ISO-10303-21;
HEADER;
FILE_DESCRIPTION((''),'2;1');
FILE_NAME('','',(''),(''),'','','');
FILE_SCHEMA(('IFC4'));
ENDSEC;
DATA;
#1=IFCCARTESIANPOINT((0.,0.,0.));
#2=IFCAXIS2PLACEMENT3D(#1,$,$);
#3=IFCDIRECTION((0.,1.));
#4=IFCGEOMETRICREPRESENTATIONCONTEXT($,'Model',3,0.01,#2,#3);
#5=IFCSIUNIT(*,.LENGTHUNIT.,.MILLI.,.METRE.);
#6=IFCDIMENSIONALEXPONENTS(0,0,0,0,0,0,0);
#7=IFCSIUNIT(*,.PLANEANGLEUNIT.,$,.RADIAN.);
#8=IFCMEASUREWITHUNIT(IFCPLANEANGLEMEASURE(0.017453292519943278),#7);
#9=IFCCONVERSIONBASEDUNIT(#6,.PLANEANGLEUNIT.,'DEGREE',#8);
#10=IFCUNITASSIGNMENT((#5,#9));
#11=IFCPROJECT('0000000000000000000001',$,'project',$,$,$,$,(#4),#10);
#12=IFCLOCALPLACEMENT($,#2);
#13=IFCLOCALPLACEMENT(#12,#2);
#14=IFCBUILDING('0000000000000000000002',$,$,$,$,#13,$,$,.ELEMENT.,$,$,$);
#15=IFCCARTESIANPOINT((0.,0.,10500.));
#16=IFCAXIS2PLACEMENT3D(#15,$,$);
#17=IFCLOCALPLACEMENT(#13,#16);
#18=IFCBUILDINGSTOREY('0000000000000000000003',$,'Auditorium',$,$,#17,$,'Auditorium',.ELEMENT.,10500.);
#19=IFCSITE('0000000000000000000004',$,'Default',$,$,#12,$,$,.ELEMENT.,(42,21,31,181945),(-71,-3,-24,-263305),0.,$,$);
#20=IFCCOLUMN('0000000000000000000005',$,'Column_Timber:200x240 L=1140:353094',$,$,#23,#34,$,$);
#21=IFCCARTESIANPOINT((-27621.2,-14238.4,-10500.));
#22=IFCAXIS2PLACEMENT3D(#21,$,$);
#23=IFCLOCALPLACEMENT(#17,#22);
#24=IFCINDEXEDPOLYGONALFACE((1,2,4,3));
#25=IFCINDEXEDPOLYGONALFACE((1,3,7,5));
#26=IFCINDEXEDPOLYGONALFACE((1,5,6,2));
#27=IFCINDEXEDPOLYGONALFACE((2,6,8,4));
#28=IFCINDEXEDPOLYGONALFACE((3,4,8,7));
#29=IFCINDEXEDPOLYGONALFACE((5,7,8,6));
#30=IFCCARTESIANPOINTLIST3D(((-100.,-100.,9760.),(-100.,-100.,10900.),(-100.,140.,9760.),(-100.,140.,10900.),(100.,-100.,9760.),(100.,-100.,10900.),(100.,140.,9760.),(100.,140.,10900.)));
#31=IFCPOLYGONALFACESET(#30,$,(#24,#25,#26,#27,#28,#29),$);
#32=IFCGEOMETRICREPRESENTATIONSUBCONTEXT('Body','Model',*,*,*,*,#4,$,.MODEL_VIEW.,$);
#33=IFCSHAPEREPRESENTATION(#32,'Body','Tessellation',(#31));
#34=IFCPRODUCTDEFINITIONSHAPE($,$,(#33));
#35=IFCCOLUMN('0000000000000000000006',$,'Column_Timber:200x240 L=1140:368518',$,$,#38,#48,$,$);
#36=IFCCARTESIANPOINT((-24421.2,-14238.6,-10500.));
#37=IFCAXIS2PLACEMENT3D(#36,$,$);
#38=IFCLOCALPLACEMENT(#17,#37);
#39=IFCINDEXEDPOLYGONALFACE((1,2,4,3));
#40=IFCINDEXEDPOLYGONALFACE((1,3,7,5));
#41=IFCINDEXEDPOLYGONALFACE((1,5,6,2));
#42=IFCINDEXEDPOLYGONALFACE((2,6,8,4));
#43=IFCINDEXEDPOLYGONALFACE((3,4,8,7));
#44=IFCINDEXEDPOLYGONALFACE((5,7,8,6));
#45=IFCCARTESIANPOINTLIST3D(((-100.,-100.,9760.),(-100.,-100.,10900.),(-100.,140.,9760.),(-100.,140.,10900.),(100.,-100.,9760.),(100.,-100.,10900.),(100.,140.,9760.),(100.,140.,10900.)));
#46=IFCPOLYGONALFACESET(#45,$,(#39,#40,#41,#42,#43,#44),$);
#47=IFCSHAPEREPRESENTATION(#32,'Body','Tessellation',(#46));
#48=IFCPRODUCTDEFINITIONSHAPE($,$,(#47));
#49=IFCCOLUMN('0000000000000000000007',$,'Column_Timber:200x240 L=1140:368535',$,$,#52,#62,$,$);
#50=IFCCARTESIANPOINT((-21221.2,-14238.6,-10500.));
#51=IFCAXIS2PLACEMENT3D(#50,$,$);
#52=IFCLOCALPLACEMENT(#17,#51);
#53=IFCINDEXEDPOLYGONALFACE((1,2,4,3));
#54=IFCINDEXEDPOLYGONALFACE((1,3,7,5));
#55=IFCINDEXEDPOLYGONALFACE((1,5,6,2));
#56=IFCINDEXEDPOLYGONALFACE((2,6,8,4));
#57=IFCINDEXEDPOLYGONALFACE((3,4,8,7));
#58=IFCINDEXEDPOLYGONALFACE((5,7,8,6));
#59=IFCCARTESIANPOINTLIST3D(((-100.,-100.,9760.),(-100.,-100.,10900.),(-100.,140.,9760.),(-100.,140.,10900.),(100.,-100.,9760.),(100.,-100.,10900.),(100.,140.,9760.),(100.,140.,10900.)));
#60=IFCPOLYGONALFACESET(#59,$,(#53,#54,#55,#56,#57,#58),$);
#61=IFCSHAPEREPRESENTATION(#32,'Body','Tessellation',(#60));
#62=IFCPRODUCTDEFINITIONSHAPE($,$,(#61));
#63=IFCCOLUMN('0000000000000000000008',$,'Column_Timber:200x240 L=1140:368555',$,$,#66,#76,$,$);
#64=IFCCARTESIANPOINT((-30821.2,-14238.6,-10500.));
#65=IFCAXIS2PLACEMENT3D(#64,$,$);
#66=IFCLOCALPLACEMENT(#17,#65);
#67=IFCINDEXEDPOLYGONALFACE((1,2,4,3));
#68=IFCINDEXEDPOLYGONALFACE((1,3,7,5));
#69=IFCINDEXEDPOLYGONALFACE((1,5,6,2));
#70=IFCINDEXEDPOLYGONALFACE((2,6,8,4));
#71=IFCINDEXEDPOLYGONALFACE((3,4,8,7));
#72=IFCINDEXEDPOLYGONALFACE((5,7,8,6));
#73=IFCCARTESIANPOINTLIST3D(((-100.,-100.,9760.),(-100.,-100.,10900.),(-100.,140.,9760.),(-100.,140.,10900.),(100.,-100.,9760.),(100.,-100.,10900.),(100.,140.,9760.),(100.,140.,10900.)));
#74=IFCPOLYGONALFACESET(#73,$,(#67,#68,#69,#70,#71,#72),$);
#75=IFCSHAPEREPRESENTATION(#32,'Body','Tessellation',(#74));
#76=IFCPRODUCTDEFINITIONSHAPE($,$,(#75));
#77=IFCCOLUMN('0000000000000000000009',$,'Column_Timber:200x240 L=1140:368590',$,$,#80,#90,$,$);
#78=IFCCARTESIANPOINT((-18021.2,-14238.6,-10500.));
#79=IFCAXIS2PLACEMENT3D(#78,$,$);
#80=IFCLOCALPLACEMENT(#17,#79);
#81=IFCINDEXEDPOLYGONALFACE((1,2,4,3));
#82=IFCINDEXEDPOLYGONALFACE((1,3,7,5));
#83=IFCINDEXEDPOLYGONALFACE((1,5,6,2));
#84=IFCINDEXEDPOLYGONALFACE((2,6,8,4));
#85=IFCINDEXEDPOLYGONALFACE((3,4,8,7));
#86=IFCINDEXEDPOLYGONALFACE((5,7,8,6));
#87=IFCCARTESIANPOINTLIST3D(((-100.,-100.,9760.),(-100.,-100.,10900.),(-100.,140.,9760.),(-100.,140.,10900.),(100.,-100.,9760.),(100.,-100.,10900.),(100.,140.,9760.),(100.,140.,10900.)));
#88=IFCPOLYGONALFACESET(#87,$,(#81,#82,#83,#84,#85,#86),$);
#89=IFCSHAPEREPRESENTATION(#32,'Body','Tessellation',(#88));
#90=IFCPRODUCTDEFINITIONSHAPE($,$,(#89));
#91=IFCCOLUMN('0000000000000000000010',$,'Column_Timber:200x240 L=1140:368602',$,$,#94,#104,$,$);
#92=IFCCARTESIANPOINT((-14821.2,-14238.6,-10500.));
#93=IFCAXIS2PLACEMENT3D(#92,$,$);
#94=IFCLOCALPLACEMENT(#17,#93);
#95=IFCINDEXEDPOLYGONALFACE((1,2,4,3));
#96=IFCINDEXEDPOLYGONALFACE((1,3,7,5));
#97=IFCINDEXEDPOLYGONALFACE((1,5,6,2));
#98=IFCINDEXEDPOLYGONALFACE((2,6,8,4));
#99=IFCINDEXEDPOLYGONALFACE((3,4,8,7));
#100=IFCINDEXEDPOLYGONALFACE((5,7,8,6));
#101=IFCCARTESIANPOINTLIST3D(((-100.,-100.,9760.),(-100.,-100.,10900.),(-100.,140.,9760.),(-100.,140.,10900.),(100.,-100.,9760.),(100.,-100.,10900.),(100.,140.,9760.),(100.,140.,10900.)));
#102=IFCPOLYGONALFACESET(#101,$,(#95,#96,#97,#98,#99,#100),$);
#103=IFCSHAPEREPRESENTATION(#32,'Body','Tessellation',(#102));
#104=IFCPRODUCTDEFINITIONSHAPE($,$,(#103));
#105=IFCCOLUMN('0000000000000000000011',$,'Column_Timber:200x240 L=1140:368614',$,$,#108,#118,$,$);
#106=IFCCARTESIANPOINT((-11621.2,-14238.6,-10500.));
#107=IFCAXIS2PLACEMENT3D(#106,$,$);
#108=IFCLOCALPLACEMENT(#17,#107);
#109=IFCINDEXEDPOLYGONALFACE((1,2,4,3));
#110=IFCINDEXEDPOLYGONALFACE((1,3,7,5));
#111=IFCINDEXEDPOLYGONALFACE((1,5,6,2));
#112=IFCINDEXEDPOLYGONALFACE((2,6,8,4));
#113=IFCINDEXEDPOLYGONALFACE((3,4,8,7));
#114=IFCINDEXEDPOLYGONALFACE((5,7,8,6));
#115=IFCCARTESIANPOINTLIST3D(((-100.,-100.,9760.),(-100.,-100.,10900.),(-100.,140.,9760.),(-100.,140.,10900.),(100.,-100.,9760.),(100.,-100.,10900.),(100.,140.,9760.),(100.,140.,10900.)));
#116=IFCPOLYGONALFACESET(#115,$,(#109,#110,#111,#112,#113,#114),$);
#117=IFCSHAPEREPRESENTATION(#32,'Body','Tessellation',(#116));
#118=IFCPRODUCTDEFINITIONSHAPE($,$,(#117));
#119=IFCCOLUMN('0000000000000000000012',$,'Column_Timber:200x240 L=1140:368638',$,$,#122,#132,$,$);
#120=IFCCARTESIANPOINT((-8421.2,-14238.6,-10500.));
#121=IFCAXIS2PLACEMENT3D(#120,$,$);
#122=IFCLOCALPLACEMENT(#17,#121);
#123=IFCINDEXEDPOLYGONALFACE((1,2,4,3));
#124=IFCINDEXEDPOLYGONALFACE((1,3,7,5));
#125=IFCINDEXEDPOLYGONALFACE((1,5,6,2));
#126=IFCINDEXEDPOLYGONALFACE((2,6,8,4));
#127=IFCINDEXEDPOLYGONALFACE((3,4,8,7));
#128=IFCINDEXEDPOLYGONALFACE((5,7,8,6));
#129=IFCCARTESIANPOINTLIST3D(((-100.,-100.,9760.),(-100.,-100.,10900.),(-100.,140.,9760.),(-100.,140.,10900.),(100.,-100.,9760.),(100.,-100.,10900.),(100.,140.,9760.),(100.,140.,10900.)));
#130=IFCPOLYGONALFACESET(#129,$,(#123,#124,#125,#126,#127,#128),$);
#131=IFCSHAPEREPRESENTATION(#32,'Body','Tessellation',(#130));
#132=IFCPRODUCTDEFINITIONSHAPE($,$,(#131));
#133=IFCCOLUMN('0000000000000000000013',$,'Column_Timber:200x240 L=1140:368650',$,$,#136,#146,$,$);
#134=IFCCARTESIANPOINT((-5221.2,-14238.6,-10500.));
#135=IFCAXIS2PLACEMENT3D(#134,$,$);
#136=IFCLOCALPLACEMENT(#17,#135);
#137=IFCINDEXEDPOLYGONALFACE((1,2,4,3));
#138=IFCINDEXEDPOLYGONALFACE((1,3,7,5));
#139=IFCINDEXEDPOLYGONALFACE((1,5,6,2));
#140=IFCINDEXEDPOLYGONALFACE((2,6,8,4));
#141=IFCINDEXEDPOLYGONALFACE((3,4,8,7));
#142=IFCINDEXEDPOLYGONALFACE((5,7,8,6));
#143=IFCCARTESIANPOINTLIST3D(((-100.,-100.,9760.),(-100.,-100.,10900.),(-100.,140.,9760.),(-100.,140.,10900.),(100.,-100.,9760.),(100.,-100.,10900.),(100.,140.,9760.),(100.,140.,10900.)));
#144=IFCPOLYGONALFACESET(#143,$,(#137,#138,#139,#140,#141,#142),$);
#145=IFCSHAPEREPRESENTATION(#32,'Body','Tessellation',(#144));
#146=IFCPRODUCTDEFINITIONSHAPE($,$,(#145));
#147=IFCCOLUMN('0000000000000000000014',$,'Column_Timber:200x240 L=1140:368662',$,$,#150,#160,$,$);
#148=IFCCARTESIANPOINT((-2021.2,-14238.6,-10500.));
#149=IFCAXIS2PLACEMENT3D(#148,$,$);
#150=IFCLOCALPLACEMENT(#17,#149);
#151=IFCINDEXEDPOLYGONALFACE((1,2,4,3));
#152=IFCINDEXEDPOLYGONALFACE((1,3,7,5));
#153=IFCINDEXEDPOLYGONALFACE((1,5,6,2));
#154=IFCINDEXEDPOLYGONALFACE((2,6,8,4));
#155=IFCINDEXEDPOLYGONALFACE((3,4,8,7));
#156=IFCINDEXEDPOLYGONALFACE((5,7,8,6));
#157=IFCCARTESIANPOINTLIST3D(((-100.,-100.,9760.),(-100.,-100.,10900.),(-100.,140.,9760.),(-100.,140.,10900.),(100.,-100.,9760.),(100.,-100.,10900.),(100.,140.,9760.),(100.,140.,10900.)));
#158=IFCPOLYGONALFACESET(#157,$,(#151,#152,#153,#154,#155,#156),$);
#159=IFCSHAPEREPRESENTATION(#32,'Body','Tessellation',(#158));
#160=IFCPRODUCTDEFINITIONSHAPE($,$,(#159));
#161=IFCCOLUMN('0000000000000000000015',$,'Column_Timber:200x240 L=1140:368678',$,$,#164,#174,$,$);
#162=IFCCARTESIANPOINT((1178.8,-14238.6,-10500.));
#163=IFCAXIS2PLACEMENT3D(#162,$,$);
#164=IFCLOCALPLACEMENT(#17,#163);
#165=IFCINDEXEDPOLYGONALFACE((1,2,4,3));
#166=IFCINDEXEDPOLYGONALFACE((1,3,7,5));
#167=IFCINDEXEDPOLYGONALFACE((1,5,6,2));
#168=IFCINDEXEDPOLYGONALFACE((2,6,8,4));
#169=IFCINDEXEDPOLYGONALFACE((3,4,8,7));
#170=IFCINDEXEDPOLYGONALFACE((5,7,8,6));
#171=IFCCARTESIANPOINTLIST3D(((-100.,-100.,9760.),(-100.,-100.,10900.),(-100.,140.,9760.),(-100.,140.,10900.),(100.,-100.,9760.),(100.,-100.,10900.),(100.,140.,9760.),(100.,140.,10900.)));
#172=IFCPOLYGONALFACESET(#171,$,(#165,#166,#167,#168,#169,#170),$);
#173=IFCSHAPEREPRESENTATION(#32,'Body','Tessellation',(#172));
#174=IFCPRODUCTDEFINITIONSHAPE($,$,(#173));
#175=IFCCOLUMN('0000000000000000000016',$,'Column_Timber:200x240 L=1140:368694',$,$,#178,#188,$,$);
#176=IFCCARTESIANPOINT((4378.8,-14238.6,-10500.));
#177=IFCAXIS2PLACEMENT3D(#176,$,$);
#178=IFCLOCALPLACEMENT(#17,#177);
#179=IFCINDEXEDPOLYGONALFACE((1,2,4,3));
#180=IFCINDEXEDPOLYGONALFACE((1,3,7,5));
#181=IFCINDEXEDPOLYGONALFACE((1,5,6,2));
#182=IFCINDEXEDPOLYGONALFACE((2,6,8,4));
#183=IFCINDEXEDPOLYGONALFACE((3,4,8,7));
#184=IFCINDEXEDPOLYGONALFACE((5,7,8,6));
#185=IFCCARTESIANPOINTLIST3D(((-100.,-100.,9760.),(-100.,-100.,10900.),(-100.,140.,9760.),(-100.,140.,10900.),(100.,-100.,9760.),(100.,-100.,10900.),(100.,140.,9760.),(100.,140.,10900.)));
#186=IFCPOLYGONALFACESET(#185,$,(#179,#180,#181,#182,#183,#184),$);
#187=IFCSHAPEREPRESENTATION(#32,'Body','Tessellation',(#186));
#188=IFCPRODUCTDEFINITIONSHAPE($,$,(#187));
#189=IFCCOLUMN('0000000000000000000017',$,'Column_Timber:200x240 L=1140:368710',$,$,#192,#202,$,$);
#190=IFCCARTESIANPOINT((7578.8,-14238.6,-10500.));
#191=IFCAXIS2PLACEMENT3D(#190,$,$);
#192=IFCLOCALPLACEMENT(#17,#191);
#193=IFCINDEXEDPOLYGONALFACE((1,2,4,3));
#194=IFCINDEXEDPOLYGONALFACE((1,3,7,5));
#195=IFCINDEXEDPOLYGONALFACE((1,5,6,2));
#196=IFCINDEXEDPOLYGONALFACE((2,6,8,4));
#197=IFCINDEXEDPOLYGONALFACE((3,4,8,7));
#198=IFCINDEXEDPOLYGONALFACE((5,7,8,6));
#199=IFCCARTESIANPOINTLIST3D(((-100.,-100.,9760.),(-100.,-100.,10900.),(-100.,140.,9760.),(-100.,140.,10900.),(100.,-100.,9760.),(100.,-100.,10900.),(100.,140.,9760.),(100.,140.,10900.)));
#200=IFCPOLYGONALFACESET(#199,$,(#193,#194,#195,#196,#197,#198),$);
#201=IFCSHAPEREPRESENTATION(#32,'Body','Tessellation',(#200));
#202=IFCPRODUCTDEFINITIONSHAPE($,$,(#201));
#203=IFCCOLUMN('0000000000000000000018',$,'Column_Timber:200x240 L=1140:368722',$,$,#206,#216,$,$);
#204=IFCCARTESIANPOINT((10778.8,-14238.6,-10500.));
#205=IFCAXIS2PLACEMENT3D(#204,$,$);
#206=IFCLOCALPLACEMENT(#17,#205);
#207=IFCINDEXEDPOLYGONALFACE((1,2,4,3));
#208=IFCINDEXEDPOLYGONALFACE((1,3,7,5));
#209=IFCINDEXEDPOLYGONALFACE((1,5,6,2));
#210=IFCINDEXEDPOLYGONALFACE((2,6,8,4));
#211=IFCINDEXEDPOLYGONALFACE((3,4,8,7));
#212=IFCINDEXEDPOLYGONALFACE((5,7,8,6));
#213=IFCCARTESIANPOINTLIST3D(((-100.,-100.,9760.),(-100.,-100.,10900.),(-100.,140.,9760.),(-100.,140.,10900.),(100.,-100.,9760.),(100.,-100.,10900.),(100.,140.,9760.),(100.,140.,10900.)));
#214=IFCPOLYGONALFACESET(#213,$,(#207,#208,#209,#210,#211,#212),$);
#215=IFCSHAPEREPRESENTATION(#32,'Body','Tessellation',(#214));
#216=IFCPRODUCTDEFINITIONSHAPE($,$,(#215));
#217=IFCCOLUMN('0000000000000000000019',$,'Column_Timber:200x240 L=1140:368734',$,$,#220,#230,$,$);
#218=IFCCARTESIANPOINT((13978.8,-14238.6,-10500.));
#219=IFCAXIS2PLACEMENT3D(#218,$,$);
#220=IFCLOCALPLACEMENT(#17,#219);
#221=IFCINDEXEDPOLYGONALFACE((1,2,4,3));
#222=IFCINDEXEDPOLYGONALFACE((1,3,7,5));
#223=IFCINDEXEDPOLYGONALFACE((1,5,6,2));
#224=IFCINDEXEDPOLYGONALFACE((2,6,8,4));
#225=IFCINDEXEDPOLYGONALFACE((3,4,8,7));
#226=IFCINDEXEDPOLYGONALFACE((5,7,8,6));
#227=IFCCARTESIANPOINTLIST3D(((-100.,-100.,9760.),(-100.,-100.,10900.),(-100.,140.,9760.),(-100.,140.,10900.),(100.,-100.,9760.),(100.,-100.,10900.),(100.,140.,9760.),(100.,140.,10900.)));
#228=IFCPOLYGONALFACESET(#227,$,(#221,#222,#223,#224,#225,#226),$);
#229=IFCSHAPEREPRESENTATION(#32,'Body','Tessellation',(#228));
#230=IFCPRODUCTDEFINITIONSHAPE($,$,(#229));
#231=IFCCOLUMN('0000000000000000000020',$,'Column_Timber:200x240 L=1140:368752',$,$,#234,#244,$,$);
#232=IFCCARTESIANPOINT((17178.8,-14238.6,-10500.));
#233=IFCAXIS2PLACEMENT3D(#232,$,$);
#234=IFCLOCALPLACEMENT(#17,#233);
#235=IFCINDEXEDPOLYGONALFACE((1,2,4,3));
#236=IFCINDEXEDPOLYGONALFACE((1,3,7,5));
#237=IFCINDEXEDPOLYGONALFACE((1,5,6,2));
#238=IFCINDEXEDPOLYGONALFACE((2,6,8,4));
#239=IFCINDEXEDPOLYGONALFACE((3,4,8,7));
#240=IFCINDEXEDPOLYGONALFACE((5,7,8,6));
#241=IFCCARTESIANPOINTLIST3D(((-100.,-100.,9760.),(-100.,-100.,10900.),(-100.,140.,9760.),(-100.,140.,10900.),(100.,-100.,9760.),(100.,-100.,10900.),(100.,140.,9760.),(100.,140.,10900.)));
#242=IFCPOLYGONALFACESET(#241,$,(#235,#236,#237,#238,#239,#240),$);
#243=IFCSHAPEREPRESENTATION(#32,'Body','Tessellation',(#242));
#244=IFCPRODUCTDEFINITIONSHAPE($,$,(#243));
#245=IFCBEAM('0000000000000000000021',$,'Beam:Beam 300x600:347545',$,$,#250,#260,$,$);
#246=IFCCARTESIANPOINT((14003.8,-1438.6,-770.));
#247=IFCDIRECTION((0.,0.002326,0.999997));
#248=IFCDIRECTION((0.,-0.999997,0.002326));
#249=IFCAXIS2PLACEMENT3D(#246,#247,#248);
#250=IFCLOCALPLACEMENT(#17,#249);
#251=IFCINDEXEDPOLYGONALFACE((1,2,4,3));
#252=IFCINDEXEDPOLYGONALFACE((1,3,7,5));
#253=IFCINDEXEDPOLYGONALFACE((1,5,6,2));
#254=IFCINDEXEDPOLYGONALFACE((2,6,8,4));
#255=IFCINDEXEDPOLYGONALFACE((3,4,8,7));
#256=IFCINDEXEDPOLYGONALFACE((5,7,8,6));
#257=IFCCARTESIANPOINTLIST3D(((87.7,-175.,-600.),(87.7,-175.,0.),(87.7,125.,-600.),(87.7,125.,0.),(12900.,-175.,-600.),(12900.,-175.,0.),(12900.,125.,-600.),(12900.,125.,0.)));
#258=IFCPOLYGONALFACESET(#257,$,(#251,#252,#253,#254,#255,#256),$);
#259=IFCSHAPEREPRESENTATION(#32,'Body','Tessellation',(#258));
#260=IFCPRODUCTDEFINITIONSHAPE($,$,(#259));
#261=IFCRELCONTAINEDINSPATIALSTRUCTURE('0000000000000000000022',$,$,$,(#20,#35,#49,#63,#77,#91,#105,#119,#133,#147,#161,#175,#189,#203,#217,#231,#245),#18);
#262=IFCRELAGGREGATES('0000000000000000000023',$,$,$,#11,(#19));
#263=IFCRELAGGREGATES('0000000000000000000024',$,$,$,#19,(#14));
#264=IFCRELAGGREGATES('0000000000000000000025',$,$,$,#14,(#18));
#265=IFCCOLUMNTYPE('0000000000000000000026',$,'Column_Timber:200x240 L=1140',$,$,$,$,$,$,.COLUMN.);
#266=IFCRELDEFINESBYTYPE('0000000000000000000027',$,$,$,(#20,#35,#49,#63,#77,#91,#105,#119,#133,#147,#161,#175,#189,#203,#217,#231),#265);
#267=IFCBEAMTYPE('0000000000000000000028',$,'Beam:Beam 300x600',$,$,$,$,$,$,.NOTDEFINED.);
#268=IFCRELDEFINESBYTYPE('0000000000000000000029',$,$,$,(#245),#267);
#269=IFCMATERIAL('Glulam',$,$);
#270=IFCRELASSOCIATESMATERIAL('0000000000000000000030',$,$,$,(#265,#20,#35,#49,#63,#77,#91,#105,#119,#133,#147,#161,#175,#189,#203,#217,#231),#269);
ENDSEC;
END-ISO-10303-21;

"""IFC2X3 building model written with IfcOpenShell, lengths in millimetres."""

from ifc_helpers import new_model, entity, si_unit, converted_unit, direction, frame, frame_2d, origin, origin_2d_with_axis, place, context, subcontext, project, spatial, rectangle, extrude, source, transform, mapped, material, type_object, type_shapes, element, save


model = new_model("IFC2X3")

# Units and contexts
model_context = context("Model", 3, precision=0.01, world=origin(), true_north=direction((0.0, 1.0)))
body_context = subcontext(model_context, "Body", "Model", "MODEL_VIEW")
ifc_project = project(units=[si_unit("LENGTHUNIT", "METRE", prefix="MILLI"), converted_unit("PLANEANGLEUNIT", "DEGREE", entity("IfcPlaneAngleMeasure", 0.017453292519943278), si_unit("PLANEANGLEUNIT", "RADIAN"), dimensions=[0, 0, 0, 0, 0, 0, 0])], contexts=[model_context])

# Site, building, storey
site_placement = place(None, origin())
site = spatial("IfcSite", under=ifc_project, at=site_placement, Name="Default", CompositionType="ELEMENT", RefLatitude=(42, 21, 31, 181945), RefLongitude=(-71, -3, -24, -263305), RefElevation=0.0)
building_placement = place(site_placement, origin())
building = spatial("IfcBuilding", under=site, at=building_placement, CompositionType="ELEMENT")
storey_placement = place(building_placement, frame((0.0, 0.0, 10500.0)))
storey = spatial("IfcBuildingStorey", under=building, at=storey_placement, Name="Auditorium", LongName="Auditorium", CompositionType="ELEMENT", Elevation=10500.0)

# Columns
ifc_material_1 = material(Name="Glulam")
column_type = type_object("IfcColumnType", Name="Column_Timber:200x240 L=1140", PredefinedType="COLUMN", material=ifc_material_1)
shared_shape = source(origin(), body_context, "Body", "SweptSolid", [
    extrude(rectangle(XDim=200.0, YDim=240.0, at=origin_2d_with_axis()), frame((0.0, 20.0, 9760.0), z_axis=(0.0, 0.0, 1.0), x_axis=(-1.0, 0.0, 0.0)), (0.0, 0.0, 1.0), 1140.0),
])
type_shapes(column_type, [shared_shape])
for number, where, name in (
    (1, (-27621.2, -14238.4, -10500.0), "Column_Timber:200x240 L=1140:353094"),
    (2, (-24421.2, -14238.6, -10500.0), "Column_Timber:200x240 L=1140:368518"),
    (3, (-21221.2, -14238.6, -10500.0), "Column_Timber:200x240 L=1140:368535"),
    (4, (-30821.2, -14238.6, -10500.0), "Column_Timber:200x240 L=1140:368555"),
    (5, (-18021.2, -14238.6, -10500.0), "Column_Timber:200x240 L=1140:368590"),
    (6, (-14821.2, -14238.6, -10500.0), "Column_Timber:200x240 L=1140:368602"),
    (7, (-11621.2, -14238.6, -10500.0), "Column_Timber:200x240 L=1140:368614"),
    (8, (-8421.2, -14238.6, -10500.0), "Column_Timber:200x240 L=1140:368638"),
    (9, (-5221.2, -14238.6, -10500.0), "Column_Timber:200x240 L=1140:368650"),
    (10, (-2021.2, -14238.6, -10500.0), "Column_Timber:200x240 L=1140:368662"),
    (11, (1178.8, -14238.6, -10500.0), "Column_Timber:200x240 L=1140:368678"),
    (12, (4378.8, -14238.6, -10500.0), "Column_Timber:200x240 L=1140:368694"),
    (13, (7578.8, -14238.6, -10500.0), "Column_Timber:200x240 L=1140:368710"),
    (14, (10778.8, -14238.6, -10500.0), "Column_Timber:200x240 L=1140:368722"),
    (15, (13978.8, -14238.6, -10500.0), "Column_Timber:200x240 L=1140:368734"),
    (16, (17178.8, -14238.6, -10500.0), "Column_Timber:200x240 L=1140:368752"),
):
    element("IfcColumn", number, at=place(storey_placement, frame(where)), inside=storey, type_object=column_type, material=ifc_material_1, Name=name, context=body_context, shape_type="MappedRepresentation", body=[
        mapped(shared_shape, transform((0.0, 0.0, 0.0), scale=1.0)),
    ])

# Beam
beam_type_1 = type_object("IfcBeamType", Name="Beam:Beam 300x600", PredefinedType="NOTDEFINED")
beam_1_placement = place(storey_placement, frame((14003.8, -1438.6, -770.0), z_axis=(0.0, 0.002326, 0.999997), x_axis=(0.0, -0.999997, 0.002326)))
element("IfcBeam", 17, at=beam_1_placement, inside=storey, type_object=beam_type_1, Name="Beam:Beam 300x600:347545", context=body_context, shape_type="SweptSolid", body=[
    extrude(rectangle(XDim=600.0, YDim=300.0, at=frame_2d((0.0, 0.0), x_axis=(1.0, 0.0))), frame((87.7, -25.0, -300.0), z_axis=(1.0, 0.0, 0.0), x_axis=(0.0, 0.0, -1.0)), (0.0, 0.0, 1.0), 12812.3),
])

save(model, "model.ifc")
